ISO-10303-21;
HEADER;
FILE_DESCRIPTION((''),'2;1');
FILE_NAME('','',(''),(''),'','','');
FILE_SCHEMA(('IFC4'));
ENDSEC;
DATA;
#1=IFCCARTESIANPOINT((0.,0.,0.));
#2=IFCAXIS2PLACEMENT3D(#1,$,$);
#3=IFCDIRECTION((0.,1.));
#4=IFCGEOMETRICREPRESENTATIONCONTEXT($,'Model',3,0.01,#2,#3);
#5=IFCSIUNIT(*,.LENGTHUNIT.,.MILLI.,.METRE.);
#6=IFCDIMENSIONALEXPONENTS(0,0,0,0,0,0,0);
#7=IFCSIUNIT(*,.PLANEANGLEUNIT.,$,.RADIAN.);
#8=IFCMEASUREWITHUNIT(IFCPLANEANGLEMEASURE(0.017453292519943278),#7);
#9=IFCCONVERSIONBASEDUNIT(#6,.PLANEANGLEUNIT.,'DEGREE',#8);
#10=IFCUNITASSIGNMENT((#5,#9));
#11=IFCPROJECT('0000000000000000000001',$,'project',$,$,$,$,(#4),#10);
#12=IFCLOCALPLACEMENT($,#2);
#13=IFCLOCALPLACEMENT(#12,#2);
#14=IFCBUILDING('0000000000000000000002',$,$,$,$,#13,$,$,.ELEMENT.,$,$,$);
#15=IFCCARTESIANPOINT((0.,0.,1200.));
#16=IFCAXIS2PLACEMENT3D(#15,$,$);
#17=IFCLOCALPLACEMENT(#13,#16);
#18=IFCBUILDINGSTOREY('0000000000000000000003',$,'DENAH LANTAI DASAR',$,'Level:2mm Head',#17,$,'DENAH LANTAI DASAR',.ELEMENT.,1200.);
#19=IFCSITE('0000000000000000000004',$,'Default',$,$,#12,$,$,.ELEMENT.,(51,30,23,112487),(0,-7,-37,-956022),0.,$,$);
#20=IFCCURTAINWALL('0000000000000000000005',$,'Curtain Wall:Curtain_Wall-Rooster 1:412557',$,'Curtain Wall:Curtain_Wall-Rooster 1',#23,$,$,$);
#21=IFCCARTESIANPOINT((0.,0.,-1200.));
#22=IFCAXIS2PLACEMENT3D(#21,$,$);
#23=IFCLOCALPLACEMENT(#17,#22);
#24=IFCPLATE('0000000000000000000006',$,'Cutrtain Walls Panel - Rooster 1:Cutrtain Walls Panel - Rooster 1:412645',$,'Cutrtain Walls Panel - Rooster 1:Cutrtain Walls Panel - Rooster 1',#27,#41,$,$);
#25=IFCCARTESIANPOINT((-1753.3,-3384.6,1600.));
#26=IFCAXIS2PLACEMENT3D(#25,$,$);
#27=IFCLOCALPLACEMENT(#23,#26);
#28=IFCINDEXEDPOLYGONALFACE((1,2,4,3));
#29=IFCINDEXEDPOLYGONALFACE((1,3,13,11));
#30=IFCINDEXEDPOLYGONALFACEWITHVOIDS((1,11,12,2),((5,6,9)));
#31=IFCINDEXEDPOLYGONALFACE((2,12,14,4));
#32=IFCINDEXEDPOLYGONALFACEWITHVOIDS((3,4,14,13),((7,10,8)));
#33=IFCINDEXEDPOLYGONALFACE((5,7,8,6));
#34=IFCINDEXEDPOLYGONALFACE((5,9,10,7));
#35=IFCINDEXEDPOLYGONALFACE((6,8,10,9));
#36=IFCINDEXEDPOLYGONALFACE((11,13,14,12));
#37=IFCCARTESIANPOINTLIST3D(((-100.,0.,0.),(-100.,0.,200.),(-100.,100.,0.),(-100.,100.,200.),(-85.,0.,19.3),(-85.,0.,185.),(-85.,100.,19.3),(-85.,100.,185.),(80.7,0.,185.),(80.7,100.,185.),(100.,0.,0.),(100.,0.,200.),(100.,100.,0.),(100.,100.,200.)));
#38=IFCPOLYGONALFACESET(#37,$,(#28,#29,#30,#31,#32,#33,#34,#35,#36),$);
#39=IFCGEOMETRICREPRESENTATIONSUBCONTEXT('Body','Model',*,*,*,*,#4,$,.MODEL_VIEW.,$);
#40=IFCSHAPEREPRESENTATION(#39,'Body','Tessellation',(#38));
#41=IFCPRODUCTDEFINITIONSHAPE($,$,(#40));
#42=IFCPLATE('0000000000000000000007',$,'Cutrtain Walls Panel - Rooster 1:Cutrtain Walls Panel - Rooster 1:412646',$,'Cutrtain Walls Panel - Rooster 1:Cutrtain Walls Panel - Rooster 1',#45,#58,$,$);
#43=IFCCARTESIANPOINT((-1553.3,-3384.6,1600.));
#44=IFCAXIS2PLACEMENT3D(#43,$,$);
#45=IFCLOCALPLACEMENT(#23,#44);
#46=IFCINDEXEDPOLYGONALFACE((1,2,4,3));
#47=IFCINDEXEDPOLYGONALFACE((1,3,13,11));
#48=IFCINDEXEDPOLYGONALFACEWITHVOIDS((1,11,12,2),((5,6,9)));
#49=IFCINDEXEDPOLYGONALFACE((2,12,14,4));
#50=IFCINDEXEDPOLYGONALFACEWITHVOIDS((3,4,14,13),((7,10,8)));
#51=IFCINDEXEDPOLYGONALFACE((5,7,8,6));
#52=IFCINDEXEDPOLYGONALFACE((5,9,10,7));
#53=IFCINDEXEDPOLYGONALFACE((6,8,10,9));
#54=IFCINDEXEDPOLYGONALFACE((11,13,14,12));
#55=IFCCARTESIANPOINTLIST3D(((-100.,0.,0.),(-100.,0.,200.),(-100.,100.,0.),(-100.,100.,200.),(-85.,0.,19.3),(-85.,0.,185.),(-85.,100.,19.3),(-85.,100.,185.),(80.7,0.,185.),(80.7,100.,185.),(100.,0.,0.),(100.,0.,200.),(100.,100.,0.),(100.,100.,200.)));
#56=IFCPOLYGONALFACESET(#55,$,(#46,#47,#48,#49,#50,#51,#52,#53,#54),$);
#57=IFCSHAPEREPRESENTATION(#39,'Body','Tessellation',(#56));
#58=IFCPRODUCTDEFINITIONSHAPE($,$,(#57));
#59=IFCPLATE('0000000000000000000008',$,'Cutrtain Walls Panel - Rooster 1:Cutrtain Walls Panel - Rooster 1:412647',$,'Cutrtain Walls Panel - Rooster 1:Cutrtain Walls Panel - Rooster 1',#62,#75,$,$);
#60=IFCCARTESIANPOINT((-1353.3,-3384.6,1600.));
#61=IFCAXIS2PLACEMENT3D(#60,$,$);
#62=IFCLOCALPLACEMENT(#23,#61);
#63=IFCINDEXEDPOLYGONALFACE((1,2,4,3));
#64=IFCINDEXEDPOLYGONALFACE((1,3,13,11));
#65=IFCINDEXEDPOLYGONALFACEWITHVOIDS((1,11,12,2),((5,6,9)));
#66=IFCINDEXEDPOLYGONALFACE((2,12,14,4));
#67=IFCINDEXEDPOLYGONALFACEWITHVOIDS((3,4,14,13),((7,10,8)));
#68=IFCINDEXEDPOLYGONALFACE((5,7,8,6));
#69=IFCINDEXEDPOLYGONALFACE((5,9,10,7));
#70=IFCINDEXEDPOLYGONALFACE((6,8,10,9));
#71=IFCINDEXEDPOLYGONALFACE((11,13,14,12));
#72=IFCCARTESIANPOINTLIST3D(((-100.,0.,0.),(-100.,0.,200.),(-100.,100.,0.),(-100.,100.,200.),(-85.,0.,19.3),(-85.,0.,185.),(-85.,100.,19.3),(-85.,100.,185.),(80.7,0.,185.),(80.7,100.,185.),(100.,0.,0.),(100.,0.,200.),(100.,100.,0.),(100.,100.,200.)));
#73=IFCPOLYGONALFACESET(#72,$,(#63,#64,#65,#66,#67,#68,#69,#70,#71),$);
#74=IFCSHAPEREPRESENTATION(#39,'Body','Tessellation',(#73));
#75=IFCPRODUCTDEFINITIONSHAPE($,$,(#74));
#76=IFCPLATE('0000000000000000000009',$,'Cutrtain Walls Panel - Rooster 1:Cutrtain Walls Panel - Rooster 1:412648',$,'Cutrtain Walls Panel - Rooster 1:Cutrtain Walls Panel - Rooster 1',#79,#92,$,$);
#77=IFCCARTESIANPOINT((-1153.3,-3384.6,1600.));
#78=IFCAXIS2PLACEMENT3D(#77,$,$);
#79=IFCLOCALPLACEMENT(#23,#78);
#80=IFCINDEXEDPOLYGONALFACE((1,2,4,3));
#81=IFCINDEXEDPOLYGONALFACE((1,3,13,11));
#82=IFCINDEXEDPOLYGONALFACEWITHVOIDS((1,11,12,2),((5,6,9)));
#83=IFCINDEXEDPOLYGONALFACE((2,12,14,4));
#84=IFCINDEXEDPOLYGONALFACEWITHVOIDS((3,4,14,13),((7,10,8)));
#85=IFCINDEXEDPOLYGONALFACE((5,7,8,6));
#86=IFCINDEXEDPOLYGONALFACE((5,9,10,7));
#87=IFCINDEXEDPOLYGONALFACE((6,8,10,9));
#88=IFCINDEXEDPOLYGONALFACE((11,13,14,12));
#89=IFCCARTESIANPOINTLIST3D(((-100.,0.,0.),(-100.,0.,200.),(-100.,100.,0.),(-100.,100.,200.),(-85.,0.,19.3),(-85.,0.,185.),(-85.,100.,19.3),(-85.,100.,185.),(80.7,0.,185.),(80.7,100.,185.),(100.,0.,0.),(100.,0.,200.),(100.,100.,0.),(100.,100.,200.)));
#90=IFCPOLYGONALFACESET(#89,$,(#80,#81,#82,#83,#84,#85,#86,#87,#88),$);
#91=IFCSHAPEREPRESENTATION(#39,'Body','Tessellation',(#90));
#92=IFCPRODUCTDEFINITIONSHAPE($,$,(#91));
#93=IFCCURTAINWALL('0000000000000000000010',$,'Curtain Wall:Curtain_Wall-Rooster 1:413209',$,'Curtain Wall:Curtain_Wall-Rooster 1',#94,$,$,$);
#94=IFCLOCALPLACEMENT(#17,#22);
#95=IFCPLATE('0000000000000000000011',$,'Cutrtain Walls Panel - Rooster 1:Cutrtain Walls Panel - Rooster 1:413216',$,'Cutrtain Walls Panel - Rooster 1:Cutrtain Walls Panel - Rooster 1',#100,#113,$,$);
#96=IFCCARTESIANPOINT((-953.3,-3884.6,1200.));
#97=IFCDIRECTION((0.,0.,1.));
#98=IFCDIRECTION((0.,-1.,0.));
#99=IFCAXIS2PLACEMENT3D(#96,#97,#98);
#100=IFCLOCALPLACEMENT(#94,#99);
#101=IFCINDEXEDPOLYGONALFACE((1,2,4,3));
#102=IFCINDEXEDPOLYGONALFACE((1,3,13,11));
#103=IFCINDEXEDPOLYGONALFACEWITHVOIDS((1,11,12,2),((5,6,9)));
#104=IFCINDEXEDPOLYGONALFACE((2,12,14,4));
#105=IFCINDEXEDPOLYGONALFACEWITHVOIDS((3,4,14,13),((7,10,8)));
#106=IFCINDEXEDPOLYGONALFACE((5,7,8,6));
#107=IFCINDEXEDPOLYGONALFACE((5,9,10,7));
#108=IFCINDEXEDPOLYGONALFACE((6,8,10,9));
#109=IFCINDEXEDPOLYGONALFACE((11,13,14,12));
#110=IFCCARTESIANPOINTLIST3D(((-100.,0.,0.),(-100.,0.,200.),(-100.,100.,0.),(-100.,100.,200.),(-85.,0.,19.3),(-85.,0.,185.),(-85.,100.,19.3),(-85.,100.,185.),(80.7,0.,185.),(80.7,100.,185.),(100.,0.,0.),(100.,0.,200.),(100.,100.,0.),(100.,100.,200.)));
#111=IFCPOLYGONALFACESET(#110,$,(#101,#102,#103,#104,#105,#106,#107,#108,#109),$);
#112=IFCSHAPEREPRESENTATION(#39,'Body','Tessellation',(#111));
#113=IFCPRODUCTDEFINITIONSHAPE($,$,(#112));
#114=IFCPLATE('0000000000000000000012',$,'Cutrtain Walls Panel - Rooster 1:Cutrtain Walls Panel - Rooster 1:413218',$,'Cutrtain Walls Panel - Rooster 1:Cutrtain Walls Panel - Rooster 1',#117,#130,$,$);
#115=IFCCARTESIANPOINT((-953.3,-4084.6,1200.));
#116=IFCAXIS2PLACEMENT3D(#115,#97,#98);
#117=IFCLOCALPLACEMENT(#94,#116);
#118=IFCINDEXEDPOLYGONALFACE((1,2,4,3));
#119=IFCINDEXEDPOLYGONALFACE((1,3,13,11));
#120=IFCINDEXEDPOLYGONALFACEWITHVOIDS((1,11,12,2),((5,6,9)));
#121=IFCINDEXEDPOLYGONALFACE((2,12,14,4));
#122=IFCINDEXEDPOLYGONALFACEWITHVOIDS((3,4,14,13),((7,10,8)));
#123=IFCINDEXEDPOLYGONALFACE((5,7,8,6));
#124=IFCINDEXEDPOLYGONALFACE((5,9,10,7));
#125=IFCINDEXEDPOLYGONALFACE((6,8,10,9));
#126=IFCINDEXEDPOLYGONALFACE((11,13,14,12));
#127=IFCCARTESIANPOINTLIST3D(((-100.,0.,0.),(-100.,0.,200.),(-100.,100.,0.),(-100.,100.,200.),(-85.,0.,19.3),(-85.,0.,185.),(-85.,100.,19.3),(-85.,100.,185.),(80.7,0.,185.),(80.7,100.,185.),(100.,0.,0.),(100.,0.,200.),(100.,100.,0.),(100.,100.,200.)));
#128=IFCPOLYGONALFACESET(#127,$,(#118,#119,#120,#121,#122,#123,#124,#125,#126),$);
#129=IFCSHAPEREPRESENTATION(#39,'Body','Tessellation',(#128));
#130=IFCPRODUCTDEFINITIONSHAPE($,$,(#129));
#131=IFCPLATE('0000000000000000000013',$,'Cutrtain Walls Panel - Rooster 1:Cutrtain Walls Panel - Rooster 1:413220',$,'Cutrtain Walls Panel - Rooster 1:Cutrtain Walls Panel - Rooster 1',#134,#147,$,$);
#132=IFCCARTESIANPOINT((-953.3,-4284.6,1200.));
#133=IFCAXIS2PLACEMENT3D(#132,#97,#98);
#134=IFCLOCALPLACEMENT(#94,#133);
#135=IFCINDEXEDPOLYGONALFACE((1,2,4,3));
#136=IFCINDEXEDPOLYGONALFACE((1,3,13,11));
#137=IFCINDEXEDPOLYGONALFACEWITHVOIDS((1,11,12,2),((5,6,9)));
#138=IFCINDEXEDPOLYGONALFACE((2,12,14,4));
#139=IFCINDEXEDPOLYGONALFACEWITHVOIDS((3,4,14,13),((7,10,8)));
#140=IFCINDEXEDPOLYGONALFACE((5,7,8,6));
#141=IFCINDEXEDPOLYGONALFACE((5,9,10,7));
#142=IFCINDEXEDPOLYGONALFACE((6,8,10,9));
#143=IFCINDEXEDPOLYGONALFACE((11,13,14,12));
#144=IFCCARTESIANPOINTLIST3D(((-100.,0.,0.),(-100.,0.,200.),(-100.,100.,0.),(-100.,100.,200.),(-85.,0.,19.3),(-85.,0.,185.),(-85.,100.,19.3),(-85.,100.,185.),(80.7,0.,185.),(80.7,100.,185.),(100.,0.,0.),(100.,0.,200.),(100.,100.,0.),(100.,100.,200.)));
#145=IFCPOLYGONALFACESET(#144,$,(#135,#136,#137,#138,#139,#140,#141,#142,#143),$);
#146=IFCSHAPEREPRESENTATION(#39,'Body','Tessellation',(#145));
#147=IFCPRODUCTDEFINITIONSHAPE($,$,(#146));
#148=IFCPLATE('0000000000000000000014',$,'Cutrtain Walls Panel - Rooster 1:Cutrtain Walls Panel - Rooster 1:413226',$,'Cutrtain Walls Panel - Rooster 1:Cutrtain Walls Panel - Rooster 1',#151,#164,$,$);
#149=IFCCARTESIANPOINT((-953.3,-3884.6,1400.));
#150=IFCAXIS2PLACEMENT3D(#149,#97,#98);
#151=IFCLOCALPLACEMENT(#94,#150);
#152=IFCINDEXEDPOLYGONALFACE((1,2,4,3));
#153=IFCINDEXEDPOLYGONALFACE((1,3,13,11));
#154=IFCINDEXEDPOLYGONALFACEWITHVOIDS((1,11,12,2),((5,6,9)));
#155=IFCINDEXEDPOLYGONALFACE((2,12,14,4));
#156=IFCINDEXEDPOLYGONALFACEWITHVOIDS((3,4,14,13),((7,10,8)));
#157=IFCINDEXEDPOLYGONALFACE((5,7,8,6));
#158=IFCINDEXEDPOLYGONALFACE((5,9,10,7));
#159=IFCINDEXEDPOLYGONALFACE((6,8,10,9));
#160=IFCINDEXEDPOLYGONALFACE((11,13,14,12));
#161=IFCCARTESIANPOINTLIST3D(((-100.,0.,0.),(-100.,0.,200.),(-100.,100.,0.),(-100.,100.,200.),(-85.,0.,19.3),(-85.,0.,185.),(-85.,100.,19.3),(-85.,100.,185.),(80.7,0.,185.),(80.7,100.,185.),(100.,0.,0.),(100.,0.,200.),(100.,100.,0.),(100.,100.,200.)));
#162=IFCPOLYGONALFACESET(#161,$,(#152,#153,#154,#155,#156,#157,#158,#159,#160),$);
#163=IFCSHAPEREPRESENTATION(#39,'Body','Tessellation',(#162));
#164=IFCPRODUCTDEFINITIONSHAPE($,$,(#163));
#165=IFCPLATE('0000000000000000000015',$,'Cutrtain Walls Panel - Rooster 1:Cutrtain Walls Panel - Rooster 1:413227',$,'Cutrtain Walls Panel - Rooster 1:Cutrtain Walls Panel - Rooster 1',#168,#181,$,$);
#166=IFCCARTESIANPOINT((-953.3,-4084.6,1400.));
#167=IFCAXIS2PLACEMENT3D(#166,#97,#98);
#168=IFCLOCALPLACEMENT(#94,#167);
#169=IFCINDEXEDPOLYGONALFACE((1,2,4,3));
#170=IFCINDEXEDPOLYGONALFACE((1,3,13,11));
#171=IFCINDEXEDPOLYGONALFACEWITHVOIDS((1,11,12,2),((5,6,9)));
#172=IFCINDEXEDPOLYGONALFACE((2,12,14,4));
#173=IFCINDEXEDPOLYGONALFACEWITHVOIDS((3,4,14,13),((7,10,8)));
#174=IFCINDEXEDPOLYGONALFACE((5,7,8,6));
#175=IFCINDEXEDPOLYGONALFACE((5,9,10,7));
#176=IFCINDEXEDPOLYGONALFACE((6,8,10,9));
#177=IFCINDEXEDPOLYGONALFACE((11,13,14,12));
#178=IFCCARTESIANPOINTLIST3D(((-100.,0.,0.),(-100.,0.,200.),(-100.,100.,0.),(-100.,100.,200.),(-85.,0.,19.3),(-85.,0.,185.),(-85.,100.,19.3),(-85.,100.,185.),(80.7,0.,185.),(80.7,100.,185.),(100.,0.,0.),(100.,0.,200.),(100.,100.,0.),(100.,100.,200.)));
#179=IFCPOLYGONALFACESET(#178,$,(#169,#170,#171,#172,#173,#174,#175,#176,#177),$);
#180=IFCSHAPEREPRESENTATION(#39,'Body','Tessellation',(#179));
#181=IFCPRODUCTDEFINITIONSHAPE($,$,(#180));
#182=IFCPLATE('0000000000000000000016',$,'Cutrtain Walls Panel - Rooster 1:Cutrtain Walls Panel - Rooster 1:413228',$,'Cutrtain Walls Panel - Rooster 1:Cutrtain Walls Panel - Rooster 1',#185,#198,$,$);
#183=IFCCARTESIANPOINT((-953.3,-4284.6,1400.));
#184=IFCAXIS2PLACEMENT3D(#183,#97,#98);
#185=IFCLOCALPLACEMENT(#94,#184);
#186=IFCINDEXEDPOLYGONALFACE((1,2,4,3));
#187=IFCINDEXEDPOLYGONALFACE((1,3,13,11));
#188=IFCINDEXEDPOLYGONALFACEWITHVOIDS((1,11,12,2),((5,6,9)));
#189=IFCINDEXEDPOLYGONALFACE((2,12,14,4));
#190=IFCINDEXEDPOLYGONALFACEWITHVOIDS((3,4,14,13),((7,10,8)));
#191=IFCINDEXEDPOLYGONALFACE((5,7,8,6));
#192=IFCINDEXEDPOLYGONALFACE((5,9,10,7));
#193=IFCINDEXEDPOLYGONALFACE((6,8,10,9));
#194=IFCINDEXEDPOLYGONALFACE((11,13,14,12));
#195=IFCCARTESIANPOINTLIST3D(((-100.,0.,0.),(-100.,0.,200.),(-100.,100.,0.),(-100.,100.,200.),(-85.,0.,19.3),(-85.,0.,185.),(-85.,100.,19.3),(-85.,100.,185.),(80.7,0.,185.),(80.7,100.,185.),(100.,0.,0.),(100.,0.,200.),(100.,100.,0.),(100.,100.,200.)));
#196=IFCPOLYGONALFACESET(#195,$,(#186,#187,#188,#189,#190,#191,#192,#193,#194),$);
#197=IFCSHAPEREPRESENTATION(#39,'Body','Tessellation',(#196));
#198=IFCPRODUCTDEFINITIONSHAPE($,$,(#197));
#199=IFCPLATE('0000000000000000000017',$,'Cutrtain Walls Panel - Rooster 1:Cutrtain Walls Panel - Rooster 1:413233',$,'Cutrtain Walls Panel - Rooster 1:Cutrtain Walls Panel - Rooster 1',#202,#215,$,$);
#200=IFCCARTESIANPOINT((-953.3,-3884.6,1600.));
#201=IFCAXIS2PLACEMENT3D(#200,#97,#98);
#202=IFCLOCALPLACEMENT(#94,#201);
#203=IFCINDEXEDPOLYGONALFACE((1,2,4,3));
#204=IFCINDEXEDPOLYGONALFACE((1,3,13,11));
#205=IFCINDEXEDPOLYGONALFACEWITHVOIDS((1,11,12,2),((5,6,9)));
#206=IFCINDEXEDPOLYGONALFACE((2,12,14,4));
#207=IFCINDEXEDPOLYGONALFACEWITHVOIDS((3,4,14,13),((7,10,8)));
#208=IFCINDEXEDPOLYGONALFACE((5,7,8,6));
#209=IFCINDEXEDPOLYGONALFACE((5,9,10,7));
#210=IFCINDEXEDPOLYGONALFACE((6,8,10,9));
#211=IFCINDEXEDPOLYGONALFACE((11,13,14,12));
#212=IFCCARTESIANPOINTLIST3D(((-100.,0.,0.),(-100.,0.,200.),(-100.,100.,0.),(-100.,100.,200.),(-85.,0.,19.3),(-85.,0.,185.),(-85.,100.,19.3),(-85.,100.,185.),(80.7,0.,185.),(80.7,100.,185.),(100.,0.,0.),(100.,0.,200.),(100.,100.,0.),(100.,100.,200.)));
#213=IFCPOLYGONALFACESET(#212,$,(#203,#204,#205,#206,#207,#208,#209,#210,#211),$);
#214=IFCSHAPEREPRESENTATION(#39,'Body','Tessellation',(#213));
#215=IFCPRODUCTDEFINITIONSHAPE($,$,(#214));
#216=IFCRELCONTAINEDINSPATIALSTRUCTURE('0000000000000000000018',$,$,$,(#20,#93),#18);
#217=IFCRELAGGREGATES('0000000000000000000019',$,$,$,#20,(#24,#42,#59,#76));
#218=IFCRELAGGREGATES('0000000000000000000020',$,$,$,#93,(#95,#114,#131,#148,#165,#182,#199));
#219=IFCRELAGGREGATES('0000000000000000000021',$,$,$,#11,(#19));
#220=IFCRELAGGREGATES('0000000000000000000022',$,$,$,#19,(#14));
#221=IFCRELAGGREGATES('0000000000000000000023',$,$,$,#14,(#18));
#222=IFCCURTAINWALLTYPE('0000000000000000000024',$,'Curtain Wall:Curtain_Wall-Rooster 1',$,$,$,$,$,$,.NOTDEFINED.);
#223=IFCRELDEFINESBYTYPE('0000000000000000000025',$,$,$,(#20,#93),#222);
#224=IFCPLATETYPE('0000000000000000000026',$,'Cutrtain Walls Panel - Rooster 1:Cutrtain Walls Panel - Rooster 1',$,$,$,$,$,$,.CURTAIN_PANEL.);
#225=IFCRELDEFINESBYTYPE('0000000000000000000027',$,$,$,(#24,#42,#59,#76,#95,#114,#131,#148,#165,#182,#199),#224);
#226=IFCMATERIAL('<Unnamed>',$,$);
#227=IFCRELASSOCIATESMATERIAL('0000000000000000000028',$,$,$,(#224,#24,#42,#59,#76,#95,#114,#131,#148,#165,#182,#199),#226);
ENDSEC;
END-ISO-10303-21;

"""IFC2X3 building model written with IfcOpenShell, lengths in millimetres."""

from ifc_helpers import new_model, entity, si_unit, converted_unit, direction, frame, origin, place, context, subcontext, project, spatial, polyline, outline, extrude, source, transform, mapped, material, type_object, type_shapes, element, aggregate, save


model = new_model("IFC2X3")

# Units and contexts
model_context = context("Model", 3, precision=0.01, world=origin(), true_north=direction((0.0, 1.0)))
body_context = subcontext(model_context, "Body", "Model", "MODEL_VIEW")
ifc_project = project(units=[si_unit("LENGTHUNIT", "METRE", prefix="MILLI"), converted_unit("PLANEANGLEUNIT", "DEGREE", entity("IfcPlaneAngleMeasure", 0.017453292519943278), si_unit("PLANEANGLEUNIT", "RADIAN"), dimensions=[0, 0, 0, 0, 0, 0, 0])], contexts=[model_context])

# Site, building, storey
site_placement = place(None, origin())
site = spatial("IfcSite", under=ifc_project, at=site_placement, Name="Default", CompositionType="ELEMENT", RefLatitude=(51, 30, 23, 112487), RefLongitude=(0, -7, -37, -956022), RefElevation=0.0)
building_placement = place(site_placement, origin())
building = spatial("IfcBuilding", under=site, at=building_placement, CompositionType="ELEMENT")
storey_placement = place(building_placement, frame((0.0, 0.0, 1200.0)))
storey = spatial("IfcBuildingStorey", under=building, at=storey_placement, Name="DENAH LANTAI DASAR", ObjectType="Level:2mm Head", LongName="DENAH LANTAI DASAR", CompositionType="ELEMENT", Elevation=1200.0)

# Curtain walls, plates
curtain_wall_type = type_object("IfcCurtainWallType", Name="Curtain Wall:Curtain_Wall-Rooster 1", PredefinedType="NOTDEFINED")
curtain_wall_1_placement = place(storey_placement, frame((0.0, 0.0, -1200.0)))
curtain_wall_1 = element("IfcCurtainWall", 1, at=curtain_wall_1_placement, inside=storey, type_object=curtain_wall_type, Name="Curtain Wall:Curtain_Wall-Rooster 1:412557", ObjectType="Curtain Wall:Curtain_Wall-Rooster 1")
ifc_material = material(Name="<Unnamed>")
plate_type_1 = type_object("IfcPlateType", Name="Cutrtain Walls Panel - Rooster 1:Cutrtain Walls Panel - Rooster 1", PredefinedType="CURTAIN_PANEL", material=ifc_material)
shared_shape_1 = source(origin(), body_context, "Body", "SweptSolid", [
    extrude(outline(polyline([(-100.0, -100.0), (100.0, -100.0), (100.0, 100.0), (-100.0, 100.0), (-100.0, -100.0)]), holes=[polyline([(80.7, 85.0), (-85.0, -80.7), (-85.0, 85.0), (80.7, 85.0)])]), frame((0.0, 0.0, 100.0), z_axis=(0.0, 1.0, 0.0), x_axis=(0.0, 0.0, -1.0)), (0.0, 0.0, 1.0), 100.0),
])
type_shapes(plate_type_1, [shared_shape_1])
plate_1_placement = place(curtain_wall_1_placement, frame((-1753.3, -3384.6, 1600.0)))
plate_1 = element("IfcPlate", 2, at=plate_1_placement, type_object=plate_type_1, material=ifc_material, Name="Cutrtain Walls Panel - Rooster 1:Cutrtain Walls Panel - Rooster 1:412645", ObjectType="Cutrtain Walls Panel - Rooster 1:Cutrtain Walls Panel - Rooster 1", context=body_context, shape_type="MappedRepresentation", body=[
    mapped(shared_shape_1, transform((0.0, 0.0, 0.0), scale=1.0)),
])
plate_2_placement = place(curtain_wall_1_placement, frame((-1553.3, -3384.6, 1600.0)))
plate_2 = element("IfcPlate", 3, at=plate_2_placement, type_object=plate_type_1, material=ifc_material, Name="Cutrtain Walls Panel - Rooster 1:Cutrtain Walls Panel - Rooster 1:412646", ObjectType="Cutrtain Walls Panel - Rooster 1:Cutrtain Walls Panel - Rooster 1", context=body_context, shape_type="MappedRepresentation", body=[
    mapped(shared_shape_1, transform((0.0, 0.0, 0.0), scale=1.0)),
])
plate_3_placement = place(curtain_wall_1_placement, frame((-1353.3, -3384.6, 1600.0)))
plate_3 = element("IfcPlate", 4, at=plate_3_placement, type_object=plate_type_1, material=ifc_material, Name="Cutrtain Walls Panel - Rooster 1:Cutrtain Walls Panel - Rooster 1:412647", ObjectType="Cutrtain Walls Panel - Rooster 1:Cutrtain Walls Panel - Rooster 1", context=body_context, shape_type="MappedRepresentation", body=[
    mapped(shared_shape_1, transform((0.0, 0.0, 0.0), scale=1.0)),
])
plate_4_placement = place(curtain_wall_1_placement, frame((-1153.3, -3384.6, 1600.0)))
plate_4 = element("IfcPlate", 5, at=plate_4_placement, type_object=plate_type_1, material=ifc_material, Name="Cutrtain Walls Panel - Rooster 1:Cutrtain Walls Panel - Rooster 1:412648", ObjectType="Cutrtain Walls Panel - Rooster 1:Cutrtain Walls Panel - Rooster 1", context=body_context, shape_type="MappedRepresentation", body=[
    mapped(shared_shape_1, transform((0.0, 0.0, 0.0), scale=1.0)),
])
aggregate(curtain_wall_1, [plate_1, plate_2, plate_3, plate_4])
curtain_wall_2_placement = place(storey_placement, frame((0.0, 0.0, -1200.0)))
curtain_wall_2 = element("IfcCurtainWall", 6, at=curtain_wall_2_placement, inside=storey, type_object=curtain_wall_type, Name="Curtain Wall:Curtain_Wall-Rooster 1:413209", ObjectType="Curtain Wall:Curtain_Wall-Rooster 1")
plate_5_placement = place(curtain_wall_2_placement, frame((-953.3, -3884.6, 1200.0), z_axis=(0.0, 0.0, 1.0), x_axis=(0.0, -1.0, 0.0)))
plate_5 = element("IfcPlate", 7, at=plate_5_placement, type_object=plate_type_1, material=ifc_material, Name="Cutrtain Walls Panel - Rooster 1:Cutrtain Walls Panel - Rooster 1:413216", ObjectType="Cutrtain Walls Panel - Rooster 1:Cutrtain Walls Panel - Rooster 1", context=body_context, shape_type="MappedRepresentation", body=[
    mapped(shared_shape_1, transform((0.0, 0.0, 0.0), scale=1.0)),
])
plate_6_placement = place(curtain_wall_2_placement, frame((-953.3, -4084.6, 1200.0), z_axis=(0.0, 0.0, 1.0), x_axis=(0.0, -1.0, 0.0)))
plate_6 = element("IfcPlate", 8, at=plate_6_placement, type_object=plate_type_1, material=ifc_material, Name="Cutrtain Walls Panel - Rooster 1:Cutrtain Walls Panel - Rooster 1:413218", ObjectType="Cutrtain Walls Panel - Rooster 1:Cutrtain Walls Panel - Rooster 1", context=body_context, shape_type="MappedRepresentation", body=[
    mapped(shared_shape_1, transform((0.0, 0.0, 0.0), scale=1.0)),
])
plate_7_placement = place(curtain_wall_2_placement, frame((-953.3, -4284.6, 1200.0), z_axis=(0.0, 0.0, 1.0), x_axis=(0.0, -1.0, 0.0)))
plate_7 = element("IfcPlate", 9, at=plate_7_placement, type_object=plate_type_1, material=ifc_material, Name="Cutrtain Walls Panel - Rooster 1:Cutrtain Walls Panel - Rooster 1:413220", ObjectType="Cutrtain Walls Panel - Rooster 1:Cutrtain Walls Panel - Rooster 1", context=body_context, shape_type="MappedRepresentation", body=[
    mapped(shared_shape_1, transform((0.0, 0.0, 0.0), scale=1.0)),
])
plate_8_placement = place(curtain_wall_2_placement, frame((-953.3, -3884.6, 1400.0), z_axis=(0.0, 0.0, 1.0), x_axis=(0.0, -1.0, 0.0)))
plate_8 = element("IfcPlate", 10, at=plate_8_placement, type_object=plate_type_1, material=ifc_material, Name="Cutrtain Walls Panel - Rooster 1:Cutrtain Walls Panel - Rooster 1:413226", ObjectType="Cutrtain Walls Panel - Rooster 1:Cutrtain Walls Panel - Rooster 1", context=body_context, shape_type="MappedRepresentation", body=[
    mapped(shared_shape_1, transform((0.0, 0.0, 0.0), scale=1.0)),
])
plate_9_placement = place(curtain_wall_2_placement, frame((-953.3, -4084.6, 1400.0), z_axis=(0.0, 0.0, 1.0), x_axis=(0.0, -1.0, 0.0)))
plate_9 = element("IfcPlate", 11, at=plate_9_placement, type_object=plate_type_1, material=ifc_material, Name="Cutrtain Walls Panel - Rooster 1:Cutrtain Walls Panel - Rooster 1:413227", ObjectType="Cutrtain Walls Panel - Rooster 1:Cutrtain Walls Panel - Rooster 1", context=body_context, shape_type="MappedRepresentation", body=[
    mapped(shared_shape_1, transform((0.0, 0.0, 0.0), scale=1.0)),
])
plate_10_placement = place(curtain_wall_2_placement, frame((-953.3, -4284.6, 1400.0), z_axis=(0.0, 0.0, 1.0), x_axis=(0.0, -1.0, 0.0)))
plate_10 = element("IfcPlate", 12, at=plate_10_placement, type_object=plate_type_1, material=ifc_material, Name="Cutrtain Walls Panel - Rooster 1:Cutrtain Walls Panel - Rooster 1:413228", ObjectType="Cutrtain Walls Panel - Rooster 1:Cutrtain Walls Panel - Rooster 1", context=body_context, shape_type="MappedRepresentation", body=[
    mapped(shared_shape_1, transform((0.0, 0.0, 0.0), scale=1.0)),
])
plate_11_placement = place(curtain_wall_2_placement, frame((-953.3, -3884.6, 1600.0), z_axis=(0.0, 0.0, 1.0), x_axis=(0.0, -1.0, 0.0)))
plate_11 = element("IfcPlate", 13, at=plate_11_placement, type_object=plate_type_1, material=ifc_material, Name="Cutrtain Walls Panel - Rooster 1:Cutrtain Walls Panel - Rooster 1:413233", ObjectType="Cutrtain Walls Panel - Rooster 1:Cutrtain Walls Panel - Rooster 1", context=body_context, shape_type="MappedRepresentation", body=[
    mapped(shared_shape_1, transform((0.0, 0.0, 0.0), scale=1.0)),
])
aggregate(curtain_wall_2, [plate_5, plate_6, plate_7, plate_8, plate_9, plate_10, plate_11])

save(model, "model.ifc")
